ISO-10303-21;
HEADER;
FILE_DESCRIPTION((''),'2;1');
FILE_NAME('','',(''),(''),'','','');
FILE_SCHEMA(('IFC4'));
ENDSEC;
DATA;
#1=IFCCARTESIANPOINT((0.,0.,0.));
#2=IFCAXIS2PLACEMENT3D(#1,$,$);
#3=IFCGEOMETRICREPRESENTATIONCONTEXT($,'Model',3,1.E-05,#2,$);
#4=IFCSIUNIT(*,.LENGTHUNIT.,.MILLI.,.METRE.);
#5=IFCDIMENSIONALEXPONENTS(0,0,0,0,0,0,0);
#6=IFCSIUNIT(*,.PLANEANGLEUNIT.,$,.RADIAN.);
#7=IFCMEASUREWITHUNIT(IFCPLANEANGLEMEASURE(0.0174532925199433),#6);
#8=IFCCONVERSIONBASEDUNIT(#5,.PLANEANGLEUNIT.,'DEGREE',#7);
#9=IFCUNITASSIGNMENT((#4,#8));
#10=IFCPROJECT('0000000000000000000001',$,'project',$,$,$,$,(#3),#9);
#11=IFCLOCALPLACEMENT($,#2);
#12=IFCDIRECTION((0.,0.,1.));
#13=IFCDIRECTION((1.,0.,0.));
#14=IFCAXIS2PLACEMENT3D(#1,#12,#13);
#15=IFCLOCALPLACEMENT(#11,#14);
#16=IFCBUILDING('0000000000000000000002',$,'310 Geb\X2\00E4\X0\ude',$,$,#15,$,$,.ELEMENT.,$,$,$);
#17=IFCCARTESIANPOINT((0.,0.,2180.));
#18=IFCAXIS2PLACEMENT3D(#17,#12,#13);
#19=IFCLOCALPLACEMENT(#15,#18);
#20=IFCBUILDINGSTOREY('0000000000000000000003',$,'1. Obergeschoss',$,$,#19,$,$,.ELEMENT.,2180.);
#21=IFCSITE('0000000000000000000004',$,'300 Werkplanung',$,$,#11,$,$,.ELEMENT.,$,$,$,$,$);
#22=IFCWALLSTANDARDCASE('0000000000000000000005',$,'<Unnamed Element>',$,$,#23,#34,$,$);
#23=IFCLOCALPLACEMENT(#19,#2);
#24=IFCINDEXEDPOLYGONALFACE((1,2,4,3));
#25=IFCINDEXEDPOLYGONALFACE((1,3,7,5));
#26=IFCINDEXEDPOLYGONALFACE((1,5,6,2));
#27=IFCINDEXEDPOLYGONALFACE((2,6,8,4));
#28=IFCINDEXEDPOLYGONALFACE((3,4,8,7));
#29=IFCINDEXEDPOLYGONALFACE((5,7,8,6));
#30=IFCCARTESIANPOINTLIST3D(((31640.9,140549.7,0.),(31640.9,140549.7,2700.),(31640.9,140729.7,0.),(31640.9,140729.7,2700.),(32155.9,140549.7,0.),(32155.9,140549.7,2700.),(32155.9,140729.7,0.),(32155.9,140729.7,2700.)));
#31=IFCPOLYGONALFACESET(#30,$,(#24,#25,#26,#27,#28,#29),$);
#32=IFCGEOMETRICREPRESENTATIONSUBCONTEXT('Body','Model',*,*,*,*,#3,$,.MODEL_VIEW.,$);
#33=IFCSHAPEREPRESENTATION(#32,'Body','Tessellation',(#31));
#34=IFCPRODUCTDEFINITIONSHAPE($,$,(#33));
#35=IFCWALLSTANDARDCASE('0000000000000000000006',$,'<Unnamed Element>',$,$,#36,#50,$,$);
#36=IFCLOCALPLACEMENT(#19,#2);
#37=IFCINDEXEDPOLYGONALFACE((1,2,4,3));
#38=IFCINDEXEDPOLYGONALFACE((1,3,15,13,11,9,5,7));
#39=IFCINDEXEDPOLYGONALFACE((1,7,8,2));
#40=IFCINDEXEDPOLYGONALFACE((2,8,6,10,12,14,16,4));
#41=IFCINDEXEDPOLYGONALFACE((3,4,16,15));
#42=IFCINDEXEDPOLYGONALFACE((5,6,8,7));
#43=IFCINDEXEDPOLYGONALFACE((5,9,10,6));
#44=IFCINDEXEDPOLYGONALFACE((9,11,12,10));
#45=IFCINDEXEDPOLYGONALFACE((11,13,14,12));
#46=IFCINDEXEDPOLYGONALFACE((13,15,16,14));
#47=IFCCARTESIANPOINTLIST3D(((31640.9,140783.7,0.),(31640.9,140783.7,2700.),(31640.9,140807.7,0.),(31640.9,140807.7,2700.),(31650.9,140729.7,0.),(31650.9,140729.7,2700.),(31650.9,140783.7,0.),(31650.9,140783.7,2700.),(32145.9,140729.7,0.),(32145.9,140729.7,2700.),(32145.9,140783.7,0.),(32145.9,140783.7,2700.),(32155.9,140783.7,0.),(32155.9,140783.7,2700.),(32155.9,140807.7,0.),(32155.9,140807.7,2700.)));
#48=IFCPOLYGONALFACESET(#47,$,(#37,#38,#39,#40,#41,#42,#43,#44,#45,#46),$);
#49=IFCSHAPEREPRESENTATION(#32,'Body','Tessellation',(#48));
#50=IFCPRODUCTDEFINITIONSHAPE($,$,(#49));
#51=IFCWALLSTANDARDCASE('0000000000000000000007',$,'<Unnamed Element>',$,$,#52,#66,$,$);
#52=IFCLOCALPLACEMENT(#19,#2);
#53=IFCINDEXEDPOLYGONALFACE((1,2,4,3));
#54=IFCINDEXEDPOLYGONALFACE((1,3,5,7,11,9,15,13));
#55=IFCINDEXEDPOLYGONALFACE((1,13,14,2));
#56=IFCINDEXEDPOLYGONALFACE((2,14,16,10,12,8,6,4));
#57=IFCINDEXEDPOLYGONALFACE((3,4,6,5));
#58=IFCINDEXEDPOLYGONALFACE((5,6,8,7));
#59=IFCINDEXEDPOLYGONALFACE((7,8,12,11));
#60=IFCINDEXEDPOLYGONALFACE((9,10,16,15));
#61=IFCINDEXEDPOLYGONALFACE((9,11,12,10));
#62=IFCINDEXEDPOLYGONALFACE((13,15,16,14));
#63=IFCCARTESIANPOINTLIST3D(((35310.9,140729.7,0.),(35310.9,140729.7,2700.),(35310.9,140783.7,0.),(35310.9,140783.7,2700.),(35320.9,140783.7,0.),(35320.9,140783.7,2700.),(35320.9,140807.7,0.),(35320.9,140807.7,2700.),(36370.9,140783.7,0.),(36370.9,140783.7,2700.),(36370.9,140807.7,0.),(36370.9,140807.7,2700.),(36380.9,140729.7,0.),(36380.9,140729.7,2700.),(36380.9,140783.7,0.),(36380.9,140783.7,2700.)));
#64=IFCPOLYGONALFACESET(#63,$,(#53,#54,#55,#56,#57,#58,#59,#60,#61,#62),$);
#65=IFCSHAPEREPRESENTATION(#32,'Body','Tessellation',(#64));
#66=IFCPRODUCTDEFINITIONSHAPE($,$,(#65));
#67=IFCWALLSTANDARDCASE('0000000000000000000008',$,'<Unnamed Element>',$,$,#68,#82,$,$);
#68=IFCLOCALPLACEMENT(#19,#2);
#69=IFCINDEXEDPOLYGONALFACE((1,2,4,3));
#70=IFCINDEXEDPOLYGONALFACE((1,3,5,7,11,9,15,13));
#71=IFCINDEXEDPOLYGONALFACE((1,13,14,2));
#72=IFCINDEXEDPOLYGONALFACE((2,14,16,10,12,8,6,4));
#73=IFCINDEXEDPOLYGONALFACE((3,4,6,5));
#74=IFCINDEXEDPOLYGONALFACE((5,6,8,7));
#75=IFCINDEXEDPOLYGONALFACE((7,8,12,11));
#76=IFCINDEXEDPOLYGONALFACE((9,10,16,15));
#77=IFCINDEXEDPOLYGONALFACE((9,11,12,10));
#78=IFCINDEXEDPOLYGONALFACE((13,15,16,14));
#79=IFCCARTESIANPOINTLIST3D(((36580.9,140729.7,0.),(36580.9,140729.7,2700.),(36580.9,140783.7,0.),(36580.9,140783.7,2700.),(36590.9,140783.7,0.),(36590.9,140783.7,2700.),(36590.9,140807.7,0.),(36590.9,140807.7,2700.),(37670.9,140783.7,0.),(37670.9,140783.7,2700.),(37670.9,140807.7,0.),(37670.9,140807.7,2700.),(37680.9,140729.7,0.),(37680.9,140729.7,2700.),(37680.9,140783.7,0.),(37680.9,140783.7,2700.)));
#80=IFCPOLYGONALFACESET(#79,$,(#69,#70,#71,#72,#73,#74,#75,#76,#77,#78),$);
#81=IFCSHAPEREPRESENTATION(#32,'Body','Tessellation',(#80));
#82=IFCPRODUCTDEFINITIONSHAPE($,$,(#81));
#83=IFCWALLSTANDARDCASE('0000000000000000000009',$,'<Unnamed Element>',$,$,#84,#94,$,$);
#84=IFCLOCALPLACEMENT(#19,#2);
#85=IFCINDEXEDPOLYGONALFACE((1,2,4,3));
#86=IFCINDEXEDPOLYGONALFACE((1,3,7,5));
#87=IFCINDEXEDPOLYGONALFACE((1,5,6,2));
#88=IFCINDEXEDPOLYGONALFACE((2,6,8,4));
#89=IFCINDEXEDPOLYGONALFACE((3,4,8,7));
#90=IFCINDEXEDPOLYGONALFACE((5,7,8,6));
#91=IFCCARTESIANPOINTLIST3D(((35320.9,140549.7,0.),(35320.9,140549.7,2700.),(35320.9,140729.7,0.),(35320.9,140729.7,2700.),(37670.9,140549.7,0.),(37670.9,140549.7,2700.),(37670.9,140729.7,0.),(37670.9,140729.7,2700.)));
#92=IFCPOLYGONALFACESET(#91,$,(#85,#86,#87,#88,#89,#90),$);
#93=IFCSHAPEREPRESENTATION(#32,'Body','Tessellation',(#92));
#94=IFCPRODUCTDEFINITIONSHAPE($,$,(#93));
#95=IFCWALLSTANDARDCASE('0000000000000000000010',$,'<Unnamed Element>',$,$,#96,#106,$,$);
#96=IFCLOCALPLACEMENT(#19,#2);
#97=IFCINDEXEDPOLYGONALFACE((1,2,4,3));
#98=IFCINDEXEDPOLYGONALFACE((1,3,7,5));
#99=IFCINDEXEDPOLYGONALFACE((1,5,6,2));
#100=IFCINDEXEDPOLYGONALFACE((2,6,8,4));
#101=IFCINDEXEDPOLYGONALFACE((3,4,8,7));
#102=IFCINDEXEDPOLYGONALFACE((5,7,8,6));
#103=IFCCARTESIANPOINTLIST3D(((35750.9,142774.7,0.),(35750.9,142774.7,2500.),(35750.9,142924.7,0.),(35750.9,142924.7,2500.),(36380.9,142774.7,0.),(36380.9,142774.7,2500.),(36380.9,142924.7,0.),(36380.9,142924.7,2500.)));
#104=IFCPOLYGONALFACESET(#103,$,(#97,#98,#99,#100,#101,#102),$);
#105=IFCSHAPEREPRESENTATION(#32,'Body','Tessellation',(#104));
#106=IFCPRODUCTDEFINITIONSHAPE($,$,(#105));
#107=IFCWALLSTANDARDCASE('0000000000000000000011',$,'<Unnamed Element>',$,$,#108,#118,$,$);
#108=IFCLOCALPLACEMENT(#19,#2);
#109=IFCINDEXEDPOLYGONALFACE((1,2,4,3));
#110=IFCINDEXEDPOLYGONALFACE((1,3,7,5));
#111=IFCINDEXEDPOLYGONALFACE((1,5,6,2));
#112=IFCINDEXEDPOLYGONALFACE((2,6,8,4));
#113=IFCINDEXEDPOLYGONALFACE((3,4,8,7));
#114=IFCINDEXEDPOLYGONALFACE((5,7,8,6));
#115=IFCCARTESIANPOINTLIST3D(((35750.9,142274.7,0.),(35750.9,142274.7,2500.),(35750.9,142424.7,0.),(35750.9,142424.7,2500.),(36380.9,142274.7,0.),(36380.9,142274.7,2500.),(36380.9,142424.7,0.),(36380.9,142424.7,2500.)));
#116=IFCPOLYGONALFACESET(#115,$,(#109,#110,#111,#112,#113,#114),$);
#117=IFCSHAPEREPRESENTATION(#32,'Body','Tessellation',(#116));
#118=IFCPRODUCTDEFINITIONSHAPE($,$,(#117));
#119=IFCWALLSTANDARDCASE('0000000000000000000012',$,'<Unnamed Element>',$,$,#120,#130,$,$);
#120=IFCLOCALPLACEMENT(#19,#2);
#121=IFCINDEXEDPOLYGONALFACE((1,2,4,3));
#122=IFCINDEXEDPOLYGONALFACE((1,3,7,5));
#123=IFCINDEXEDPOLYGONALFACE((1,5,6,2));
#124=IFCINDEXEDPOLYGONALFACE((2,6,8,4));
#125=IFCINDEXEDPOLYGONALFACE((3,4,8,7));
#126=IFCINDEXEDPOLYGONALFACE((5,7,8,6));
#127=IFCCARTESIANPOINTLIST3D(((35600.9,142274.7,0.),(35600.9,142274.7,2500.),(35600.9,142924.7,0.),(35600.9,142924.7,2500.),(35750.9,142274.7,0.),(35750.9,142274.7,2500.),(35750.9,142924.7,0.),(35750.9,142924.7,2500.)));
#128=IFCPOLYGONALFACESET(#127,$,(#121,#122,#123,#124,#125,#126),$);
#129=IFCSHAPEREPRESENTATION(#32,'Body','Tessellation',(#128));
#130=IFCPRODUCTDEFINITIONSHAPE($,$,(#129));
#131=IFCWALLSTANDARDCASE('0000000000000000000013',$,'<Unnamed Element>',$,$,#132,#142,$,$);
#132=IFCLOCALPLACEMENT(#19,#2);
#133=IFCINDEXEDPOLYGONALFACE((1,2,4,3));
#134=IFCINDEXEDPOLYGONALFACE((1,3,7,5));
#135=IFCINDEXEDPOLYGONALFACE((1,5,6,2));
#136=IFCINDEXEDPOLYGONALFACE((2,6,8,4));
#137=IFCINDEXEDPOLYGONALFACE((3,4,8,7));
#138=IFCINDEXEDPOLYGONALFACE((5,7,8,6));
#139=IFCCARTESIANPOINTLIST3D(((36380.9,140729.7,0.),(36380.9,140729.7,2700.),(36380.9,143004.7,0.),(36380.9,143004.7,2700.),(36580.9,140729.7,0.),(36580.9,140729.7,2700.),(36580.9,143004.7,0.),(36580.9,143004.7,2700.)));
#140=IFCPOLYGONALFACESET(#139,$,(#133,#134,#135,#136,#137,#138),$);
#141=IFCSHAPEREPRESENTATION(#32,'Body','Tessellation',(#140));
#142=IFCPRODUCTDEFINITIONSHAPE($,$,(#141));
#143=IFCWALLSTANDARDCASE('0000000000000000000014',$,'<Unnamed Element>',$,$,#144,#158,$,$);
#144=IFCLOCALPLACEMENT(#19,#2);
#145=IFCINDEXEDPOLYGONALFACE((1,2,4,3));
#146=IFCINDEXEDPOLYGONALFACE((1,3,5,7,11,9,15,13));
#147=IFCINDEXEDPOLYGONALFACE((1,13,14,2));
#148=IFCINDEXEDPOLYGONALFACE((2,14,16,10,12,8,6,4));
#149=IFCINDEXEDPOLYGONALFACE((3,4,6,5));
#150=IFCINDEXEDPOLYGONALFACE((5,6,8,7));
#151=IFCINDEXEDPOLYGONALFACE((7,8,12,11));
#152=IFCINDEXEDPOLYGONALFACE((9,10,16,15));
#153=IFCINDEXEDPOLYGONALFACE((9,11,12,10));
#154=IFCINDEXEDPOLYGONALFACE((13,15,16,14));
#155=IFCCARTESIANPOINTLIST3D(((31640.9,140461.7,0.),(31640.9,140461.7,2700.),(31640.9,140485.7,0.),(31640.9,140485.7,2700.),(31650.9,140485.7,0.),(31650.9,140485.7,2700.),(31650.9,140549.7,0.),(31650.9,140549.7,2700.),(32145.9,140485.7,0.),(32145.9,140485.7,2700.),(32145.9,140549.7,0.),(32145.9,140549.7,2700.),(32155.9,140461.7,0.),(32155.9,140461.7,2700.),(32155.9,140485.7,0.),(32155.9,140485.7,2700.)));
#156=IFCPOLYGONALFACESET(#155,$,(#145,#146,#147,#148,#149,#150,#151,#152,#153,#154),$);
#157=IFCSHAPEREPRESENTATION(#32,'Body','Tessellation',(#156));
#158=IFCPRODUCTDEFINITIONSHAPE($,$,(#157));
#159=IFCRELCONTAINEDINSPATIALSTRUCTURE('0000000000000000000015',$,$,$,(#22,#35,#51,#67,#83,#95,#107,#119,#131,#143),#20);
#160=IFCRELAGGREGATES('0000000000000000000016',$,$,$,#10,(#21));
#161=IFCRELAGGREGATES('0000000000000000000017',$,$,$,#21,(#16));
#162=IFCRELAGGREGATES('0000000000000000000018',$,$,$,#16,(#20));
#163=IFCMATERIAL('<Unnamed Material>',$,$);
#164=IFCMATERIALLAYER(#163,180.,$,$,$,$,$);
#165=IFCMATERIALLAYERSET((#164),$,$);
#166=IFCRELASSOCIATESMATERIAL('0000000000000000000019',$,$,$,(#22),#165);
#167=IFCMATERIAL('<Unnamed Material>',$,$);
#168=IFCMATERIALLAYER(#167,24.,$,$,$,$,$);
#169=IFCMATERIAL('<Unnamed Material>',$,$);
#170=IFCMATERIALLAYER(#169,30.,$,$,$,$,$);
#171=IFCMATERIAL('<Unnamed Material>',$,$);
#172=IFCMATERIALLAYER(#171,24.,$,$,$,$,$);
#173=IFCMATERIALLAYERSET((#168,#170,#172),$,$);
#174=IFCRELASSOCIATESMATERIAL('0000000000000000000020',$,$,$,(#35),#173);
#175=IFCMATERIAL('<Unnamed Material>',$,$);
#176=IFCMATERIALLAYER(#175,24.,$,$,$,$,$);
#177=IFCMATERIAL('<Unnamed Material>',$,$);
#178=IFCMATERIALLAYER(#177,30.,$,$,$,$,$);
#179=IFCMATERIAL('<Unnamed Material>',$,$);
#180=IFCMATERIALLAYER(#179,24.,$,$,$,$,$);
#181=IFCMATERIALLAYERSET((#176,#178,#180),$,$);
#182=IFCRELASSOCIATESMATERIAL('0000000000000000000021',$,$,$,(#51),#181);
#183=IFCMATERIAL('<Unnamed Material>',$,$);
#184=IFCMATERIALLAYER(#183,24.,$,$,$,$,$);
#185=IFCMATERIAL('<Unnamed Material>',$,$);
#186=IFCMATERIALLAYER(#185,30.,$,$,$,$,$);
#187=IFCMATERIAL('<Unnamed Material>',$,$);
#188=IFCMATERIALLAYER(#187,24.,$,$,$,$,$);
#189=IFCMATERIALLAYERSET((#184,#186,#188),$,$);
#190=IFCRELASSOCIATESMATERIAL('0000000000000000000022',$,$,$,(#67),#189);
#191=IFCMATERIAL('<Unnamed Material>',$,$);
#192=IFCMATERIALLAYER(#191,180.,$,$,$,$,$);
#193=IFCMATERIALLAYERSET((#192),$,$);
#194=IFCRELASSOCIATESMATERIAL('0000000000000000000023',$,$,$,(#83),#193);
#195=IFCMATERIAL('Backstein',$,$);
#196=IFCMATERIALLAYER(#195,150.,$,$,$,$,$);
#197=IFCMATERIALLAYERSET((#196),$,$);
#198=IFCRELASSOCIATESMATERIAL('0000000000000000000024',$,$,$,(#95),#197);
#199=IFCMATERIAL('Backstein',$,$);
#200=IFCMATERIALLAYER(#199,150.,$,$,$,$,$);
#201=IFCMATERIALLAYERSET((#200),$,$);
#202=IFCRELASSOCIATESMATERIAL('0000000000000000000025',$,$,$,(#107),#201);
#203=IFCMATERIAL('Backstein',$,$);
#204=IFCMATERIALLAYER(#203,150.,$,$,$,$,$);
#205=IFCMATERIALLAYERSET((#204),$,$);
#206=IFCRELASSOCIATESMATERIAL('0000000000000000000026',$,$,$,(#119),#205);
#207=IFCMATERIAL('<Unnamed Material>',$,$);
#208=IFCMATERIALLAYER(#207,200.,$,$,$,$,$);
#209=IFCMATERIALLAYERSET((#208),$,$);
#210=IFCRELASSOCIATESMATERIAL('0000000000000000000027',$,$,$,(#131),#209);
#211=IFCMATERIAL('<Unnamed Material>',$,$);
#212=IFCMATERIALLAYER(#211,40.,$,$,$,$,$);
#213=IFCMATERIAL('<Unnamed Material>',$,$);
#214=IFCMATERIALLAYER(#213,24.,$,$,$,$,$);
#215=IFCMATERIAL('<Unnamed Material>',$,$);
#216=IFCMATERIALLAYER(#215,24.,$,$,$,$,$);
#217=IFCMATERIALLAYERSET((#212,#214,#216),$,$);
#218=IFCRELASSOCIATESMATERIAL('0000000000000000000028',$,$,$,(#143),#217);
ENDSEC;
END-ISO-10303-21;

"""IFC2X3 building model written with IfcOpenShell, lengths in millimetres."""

from ifc_helpers import new_model, entity, si_unit, converted_unit, frame, frame_2d, origin, origin_with_axes, place, context, subcontext, project, spatial, polyline, rectangle, outline, extrude, material, layer, layer_set, layer_usage, element, save


model = new_model("IFC2X3")

# Units and contexts
model_context = context("Model", 3, precision=1e-05, world=origin())
body_context = subcontext(model_context, "Body", "Model", "MODEL_VIEW")
ifc_project = project(units=[si_unit("LENGTHUNIT", "METRE", prefix="MILLI"), converted_unit("PLANEANGLEUNIT", "DEGREE", entity("IfcPlaneAngleMeasure", 0.0174532925199433), si_unit("PLANEANGLEUNIT", "RADIAN"), dimensions=[0, 0, 0, 0, 0, 0, 0])], contexts=[model_context])

# Site, building, storey
site_placement = place(None, origin())
site = spatial("IfcSite", under=ifc_project, at=site_placement, Name="300 Werkplanung", CompositionType="ELEMENT")
building_placement = place(site_placement, origin_with_axes())
building = spatial("IfcBuilding", under=site, at=building_placement, Name="310 Gebäude", CompositionType="ELEMENT")
storey_placement = place(building_placement, frame((0.0, 0.0, 2180.0), z_axis=(0.0, 0.0, 1.0), x_axis=(1.0, 0.0, 0.0)))
storey = spatial("IfcBuildingStorey", under=building, at=storey_placement, Name="1. Obergeschoss", CompositionType="ELEMENT", Elevation=2180.0)

# Walls
ifc_material_1 = material(Name="<Unnamed Material>")
ifc_layer_1 = layer(ifc_material_1, 180.0)
ifc_layer_set_1 = layer_set([ifc_layer_1])
ifc_layer_usage_1 = layer_usage(ifc_layer_set_1, "AXIS2", "POSITIVE", 0.0)
wall_1_placement = place(storey_placement, frame((31640.9, 140549.7, 0.0), z_axis=(0.0, 0.0, 1.0), x_axis=(1.0, 0.0, 0.0)))
element("IfcWallStandardCase", 1, at=wall_1_placement, inside=storey, material=ifc_layer_usage_1, Name="<Unnamed Element>", context=body_context, shape_type="SweptSolid", body=[
    extrude(rectangle(XDim=515.0, YDim=180.0, at=frame_2d((257.5, 90.0), x_axis=(1.0, 0.0))), origin_with_axes(), (0.0, 0.0, 1.0), 2700.0),
])
ifc_material_2 = material(Name="<Unnamed Material>")
ifc_layer_2 = layer(ifc_material_2, 24.0)
ifc_material_3 = material(Name="<Unnamed Material>")
ifc_layer_3 = layer(ifc_material_3, 30.0)
ifc_material_4 = material(Name="<Unnamed Material>")
ifc_layer_4 = layer(ifc_material_4, 24.0)
ifc_layer_set_2 = layer_set([ifc_layer_2, ifc_layer_3, ifc_layer_4])
ifc_layer_usage_2 = layer_usage(ifc_layer_set_2, "AXIS2", "POSITIVE", 0.0)
wall_2_placement = place(storey_placement, frame((31650.9, 140729.7, 0.0), z_axis=(0.0, 0.0, 1.0), x_axis=(1.0, 0.0, 0.0)))
element("IfcWallStandardCase", 2, at=wall_2_placement, inside=storey, material=ifc_layer_usage_2, Name="<Unnamed Element>", context=body_context, shape_type="SweptSolid", body=[
    extrude(outline(polyline([(0.0, 0.0), (495.0, 0.0), (495.0, 54.0), (505.0, 54.0), (505.0, 78.0), (-10.0, 78.0), (-10.0, 54.0), (0.0, 54.0), (0.0, 0.0)])), origin_with_axes(), (0.0, 0.0, 1.0), 2700.0),
])
ifc_material_5 = material(Name="<Unnamed Material>")
ifc_layer_5 = layer(ifc_material_5, 24.0)
ifc_material_6 = material(Name="<Unnamed Material>")
ifc_layer_6 = layer(ifc_material_6, 30.0)
ifc_material_7 = material(Name="<Unnamed Material>")
ifc_layer_7 = layer(ifc_material_7, 24.0)
ifc_layer_set_3 = layer_set([ifc_layer_5, ifc_layer_6, ifc_layer_7])
ifc_layer_usage_3 = layer_usage(ifc_layer_set_3, "AXIS2", "POSITIVE", 0.0)
wall_3_placement = place(storey_placement, frame((35310.9, 140729.7, 0.0), z_axis=(0.0, 0.0, 1.0), x_axis=(1.0, 0.0, 0.0)))
element("IfcWallStandardCase", 3, at=wall_3_placement, inside=storey, material=ifc_layer_usage_3, Name="<Unnamed Element>", context=body_context, shape_type="SweptSolid", body=[
    extrude(outline(polyline([(0.0, 0.0), (1070.0, 0.0), (1070.0, 54.0), (1060.0, 54.0), (1060.0, 78.0), (10.0, 78.0), (10.0, 54.0), (0.0, 54.0), (0.0, 0.0)])), origin_with_axes(), (0.0, 0.0, 1.0), 2700.0),
])
ifc_material_8 = material(Name="<Unnamed Material>")
ifc_layer_8 = layer(ifc_material_8, 24.0)
ifc_material_9 = material(Name="<Unnamed Material>")
ifc_layer_9 = layer(ifc_material_9, 30.0)
ifc_material_10 = material(Name="<Unnamed Material>")
ifc_layer_10 = layer(ifc_material_10, 24.0)
ifc_layer_set_4 = layer_set([ifc_layer_8, ifc_layer_9, ifc_layer_10])
ifc_layer_usage_4 = layer_usage(ifc_layer_set_4, "AXIS2", "POSITIVE", 0.0)
wall_4_placement = place(storey_placement, frame((36580.9, 140729.7, 0.0), z_axis=(0.0, 0.0, 1.0), x_axis=(1.0, 0.0, 0.0)))
element("IfcWallStandardCase", 4, at=wall_4_placement, inside=storey, material=ifc_layer_usage_4, Name="<Unnamed Element>", context=body_context, shape_type="SweptSolid", body=[
    extrude(outline(polyline([(0.0, 0.0), (1100.0, 0.0), (1100.0, 54.0), (1090.0, 54.0), (1090.0, 78.0), (10.0, 78.0), (10.0, 54.0), (0.0, 54.0), (0.0, 0.0)])), origin_with_axes(), (0.0, 0.0, 1.0), 2700.0),
])
ifc_material_11 = material(Name="<Unnamed Material>")
ifc_layer_11 = layer(ifc_material_11, 180.0)
ifc_layer_set_5 = layer_set([ifc_layer_11])
ifc_layer_usage_5 = layer_usage(ifc_layer_set_5, "AXIS2", "POSITIVE", 0.0)
wall_5_placement = place(storey_placement, frame((35320.9, 140549.7, 0.0), z_axis=(0.0, 0.0, 1.0), x_axis=(1.0, 0.0, 0.0)))
element("IfcWallStandardCase", 5, at=wall_5_placement, inside=storey, material=ifc_layer_usage_5, Name="<Unnamed Element>", context=body_context, shape_type="SweptSolid", body=[
    extrude(rectangle(XDim=2350.0, YDim=180.0, at=frame_2d((1175.0, 90.0), x_axis=(1.0, 0.0))), origin_with_axes(), (0.0, 0.0, 1.0), 2700.0),
])
ifc_material_12 = material(Name="Backstein")
ifc_layer_12 = layer(ifc_material_12, 150.0)
ifc_layer_set_6 = layer_set([ifc_layer_12])
ifc_layer_usage_6 = layer_usage(ifc_layer_set_6, "AXIS2", "POSITIVE", 0.0)
wall_6_placement = place(storey_placement, frame((36380.9, 142924.7, 0.0), z_axis=(0.0, 0.0, 1.0), x_axis=(-1.0, 0.0, 0.0)))
element("IfcWallStandardCase", 6, at=wall_6_placement, inside=storey, material=ifc_layer_usage_6, Name="<Unnamed Element>", context=body_context, shape_type="SweptSolid", body=[
    extrude(rectangle(XDim=630.0, YDim=150.0, at=frame_2d((315.0, 75.0), x_axis=(1.0, 0.0))), origin_with_axes(), (0.0, 0.0, 1.0), 2500.0),
])
ifc_material_13 = material(Name="Backstein")
ifc_layer_13 = layer(ifc_material_13, 150.0)
ifc_layer_set_7 = layer_set([ifc_layer_13])
ifc_layer_usage_7 = layer_usage(ifc_layer_set_7, "AXIS2", "POSITIVE", 0.0)
wall_7_placement = place(storey_placement, frame((35750.9, 142274.7, 0.0), z_axis=(0.0, 0.0, 1.0), x_axis=(1.0, 0.0, 0.0)))
element("IfcWallStandardCase", 7, at=wall_7_placement, inside=storey, material=ifc_layer_usage_7, Name="<Unnamed Element>", context=body_context, shape_type="SweptSolid", body=[
    extrude(rectangle(XDim=630.0, YDim=150.0, at=frame_2d((315.0, 75.0), x_axis=(1.0, 0.0))), origin_with_axes(), (0.0, 0.0, 1.0), 2500.0),
])
ifc_material_14 = material(Name="Backstein")
ifc_layer_14 = layer(ifc_material_14, 150.0)
ifc_layer_set_8 = layer_set([ifc_layer_14])
ifc_layer_usage_8 = layer_usage(ifc_layer_set_8, "AXIS2", "POSITIVE", 0.0)
wall_8_placement = place(storey_placement, frame((35750.9, 142274.7, 0.0), z_axis=(0.0, 0.0, 1.0), x_axis=(0.0, 1.0, 0.0)))
element("IfcWallStandardCase", 8, at=wall_8_placement, inside=storey, material=ifc_layer_usage_8, Name="<Unnamed Element>", context=body_context, shape_type="SweptSolid", body=[
    extrude(rectangle(XDim=650.0, YDim=150.0, at=frame_2d((325.0, 75.0), x_axis=(1.0, 0.0))), origin_with_axes(), (0.0, 0.0, 1.0), 2500.0),
])
ifc_material_15 = material(Name="<Unnamed Material>")
ifc_layer_15 = layer(ifc_material_15, 200.0)
ifc_layer_set_9 = layer_set([ifc_layer_15])
ifc_layer_usage_9 = layer_usage(ifc_layer_set_9, "AXIS2", "POSITIVE", -100.0)
wall_9_placement = place(storey_placement, frame((36380.9, 143004.7, 0.0), z_axis=(0.0, 0.0, 1.0), x_axis=(0.0, -1.0, 0.0)))
element("IfcWallStandardCase", 9, at=wall_9_placement, inside=storey, material=ifc_layer_usage_9, Name="<Unnamed Element>", context=body_context, shape_type="SweptSolid", body=[
    extrude(rectangle(XDim=2275.0, YDim=200.0, at=frame_2d((1137.5, 100.0), x_axis=(1.0, 0.0))), origin_with_axes(), (0.0, 0.0, 1.0), 2700.0),
])
ifc_material_16 = material(Name="<Unnamed Material>")
ifc_layer_16 = layer(ifc_material_16, 40.0)
ifc_material_17 = material(Name="<Unnamed Material>")
ifc_layer_17 = layer(ifc_material_17, 24.0)
ifc_material_18 = material(Name="<Unnamed Material>")
ifc_layer_18 = layer(ifc_material_18, 24.0)
ifc_layer_set_10 = layer_set([ifc_layer_16, ifc_layer_17, ifc_layer_18])
ifc_layer_usage_10 = layer_usage(ifc_layer_set_10, "AXIS2", "POSITIVE", 0.0)
wall_10_placement = place(storey_placement, frame((32145.9, 140549.7, 0.0), z_axis=(0.0, 0.0, 1.0), x_axis=(-1.0, 0.0, 0.0)))
element("IfcWallStandardCase", 10, at=wall_10_placement, inside=storey, material=ifc_layer_usage_10, Name="<Unnamed Element>", context=body_context, shape_type="SweptSolid", body=[
    extrude(outline(polyline([(0.0, 0.0), (495.0, 0.0), (495.0, 64.0), (505.0, 64.0), (505.0, 88.0), (-10.0, 88.0), (-10.0, 64.0), (0.0, 64.0), (0.0, 0.0)])), origin_with_axes(), (0.0, 0.0, 1.0), 2700.0),
])

save(model, "model.ifc")
